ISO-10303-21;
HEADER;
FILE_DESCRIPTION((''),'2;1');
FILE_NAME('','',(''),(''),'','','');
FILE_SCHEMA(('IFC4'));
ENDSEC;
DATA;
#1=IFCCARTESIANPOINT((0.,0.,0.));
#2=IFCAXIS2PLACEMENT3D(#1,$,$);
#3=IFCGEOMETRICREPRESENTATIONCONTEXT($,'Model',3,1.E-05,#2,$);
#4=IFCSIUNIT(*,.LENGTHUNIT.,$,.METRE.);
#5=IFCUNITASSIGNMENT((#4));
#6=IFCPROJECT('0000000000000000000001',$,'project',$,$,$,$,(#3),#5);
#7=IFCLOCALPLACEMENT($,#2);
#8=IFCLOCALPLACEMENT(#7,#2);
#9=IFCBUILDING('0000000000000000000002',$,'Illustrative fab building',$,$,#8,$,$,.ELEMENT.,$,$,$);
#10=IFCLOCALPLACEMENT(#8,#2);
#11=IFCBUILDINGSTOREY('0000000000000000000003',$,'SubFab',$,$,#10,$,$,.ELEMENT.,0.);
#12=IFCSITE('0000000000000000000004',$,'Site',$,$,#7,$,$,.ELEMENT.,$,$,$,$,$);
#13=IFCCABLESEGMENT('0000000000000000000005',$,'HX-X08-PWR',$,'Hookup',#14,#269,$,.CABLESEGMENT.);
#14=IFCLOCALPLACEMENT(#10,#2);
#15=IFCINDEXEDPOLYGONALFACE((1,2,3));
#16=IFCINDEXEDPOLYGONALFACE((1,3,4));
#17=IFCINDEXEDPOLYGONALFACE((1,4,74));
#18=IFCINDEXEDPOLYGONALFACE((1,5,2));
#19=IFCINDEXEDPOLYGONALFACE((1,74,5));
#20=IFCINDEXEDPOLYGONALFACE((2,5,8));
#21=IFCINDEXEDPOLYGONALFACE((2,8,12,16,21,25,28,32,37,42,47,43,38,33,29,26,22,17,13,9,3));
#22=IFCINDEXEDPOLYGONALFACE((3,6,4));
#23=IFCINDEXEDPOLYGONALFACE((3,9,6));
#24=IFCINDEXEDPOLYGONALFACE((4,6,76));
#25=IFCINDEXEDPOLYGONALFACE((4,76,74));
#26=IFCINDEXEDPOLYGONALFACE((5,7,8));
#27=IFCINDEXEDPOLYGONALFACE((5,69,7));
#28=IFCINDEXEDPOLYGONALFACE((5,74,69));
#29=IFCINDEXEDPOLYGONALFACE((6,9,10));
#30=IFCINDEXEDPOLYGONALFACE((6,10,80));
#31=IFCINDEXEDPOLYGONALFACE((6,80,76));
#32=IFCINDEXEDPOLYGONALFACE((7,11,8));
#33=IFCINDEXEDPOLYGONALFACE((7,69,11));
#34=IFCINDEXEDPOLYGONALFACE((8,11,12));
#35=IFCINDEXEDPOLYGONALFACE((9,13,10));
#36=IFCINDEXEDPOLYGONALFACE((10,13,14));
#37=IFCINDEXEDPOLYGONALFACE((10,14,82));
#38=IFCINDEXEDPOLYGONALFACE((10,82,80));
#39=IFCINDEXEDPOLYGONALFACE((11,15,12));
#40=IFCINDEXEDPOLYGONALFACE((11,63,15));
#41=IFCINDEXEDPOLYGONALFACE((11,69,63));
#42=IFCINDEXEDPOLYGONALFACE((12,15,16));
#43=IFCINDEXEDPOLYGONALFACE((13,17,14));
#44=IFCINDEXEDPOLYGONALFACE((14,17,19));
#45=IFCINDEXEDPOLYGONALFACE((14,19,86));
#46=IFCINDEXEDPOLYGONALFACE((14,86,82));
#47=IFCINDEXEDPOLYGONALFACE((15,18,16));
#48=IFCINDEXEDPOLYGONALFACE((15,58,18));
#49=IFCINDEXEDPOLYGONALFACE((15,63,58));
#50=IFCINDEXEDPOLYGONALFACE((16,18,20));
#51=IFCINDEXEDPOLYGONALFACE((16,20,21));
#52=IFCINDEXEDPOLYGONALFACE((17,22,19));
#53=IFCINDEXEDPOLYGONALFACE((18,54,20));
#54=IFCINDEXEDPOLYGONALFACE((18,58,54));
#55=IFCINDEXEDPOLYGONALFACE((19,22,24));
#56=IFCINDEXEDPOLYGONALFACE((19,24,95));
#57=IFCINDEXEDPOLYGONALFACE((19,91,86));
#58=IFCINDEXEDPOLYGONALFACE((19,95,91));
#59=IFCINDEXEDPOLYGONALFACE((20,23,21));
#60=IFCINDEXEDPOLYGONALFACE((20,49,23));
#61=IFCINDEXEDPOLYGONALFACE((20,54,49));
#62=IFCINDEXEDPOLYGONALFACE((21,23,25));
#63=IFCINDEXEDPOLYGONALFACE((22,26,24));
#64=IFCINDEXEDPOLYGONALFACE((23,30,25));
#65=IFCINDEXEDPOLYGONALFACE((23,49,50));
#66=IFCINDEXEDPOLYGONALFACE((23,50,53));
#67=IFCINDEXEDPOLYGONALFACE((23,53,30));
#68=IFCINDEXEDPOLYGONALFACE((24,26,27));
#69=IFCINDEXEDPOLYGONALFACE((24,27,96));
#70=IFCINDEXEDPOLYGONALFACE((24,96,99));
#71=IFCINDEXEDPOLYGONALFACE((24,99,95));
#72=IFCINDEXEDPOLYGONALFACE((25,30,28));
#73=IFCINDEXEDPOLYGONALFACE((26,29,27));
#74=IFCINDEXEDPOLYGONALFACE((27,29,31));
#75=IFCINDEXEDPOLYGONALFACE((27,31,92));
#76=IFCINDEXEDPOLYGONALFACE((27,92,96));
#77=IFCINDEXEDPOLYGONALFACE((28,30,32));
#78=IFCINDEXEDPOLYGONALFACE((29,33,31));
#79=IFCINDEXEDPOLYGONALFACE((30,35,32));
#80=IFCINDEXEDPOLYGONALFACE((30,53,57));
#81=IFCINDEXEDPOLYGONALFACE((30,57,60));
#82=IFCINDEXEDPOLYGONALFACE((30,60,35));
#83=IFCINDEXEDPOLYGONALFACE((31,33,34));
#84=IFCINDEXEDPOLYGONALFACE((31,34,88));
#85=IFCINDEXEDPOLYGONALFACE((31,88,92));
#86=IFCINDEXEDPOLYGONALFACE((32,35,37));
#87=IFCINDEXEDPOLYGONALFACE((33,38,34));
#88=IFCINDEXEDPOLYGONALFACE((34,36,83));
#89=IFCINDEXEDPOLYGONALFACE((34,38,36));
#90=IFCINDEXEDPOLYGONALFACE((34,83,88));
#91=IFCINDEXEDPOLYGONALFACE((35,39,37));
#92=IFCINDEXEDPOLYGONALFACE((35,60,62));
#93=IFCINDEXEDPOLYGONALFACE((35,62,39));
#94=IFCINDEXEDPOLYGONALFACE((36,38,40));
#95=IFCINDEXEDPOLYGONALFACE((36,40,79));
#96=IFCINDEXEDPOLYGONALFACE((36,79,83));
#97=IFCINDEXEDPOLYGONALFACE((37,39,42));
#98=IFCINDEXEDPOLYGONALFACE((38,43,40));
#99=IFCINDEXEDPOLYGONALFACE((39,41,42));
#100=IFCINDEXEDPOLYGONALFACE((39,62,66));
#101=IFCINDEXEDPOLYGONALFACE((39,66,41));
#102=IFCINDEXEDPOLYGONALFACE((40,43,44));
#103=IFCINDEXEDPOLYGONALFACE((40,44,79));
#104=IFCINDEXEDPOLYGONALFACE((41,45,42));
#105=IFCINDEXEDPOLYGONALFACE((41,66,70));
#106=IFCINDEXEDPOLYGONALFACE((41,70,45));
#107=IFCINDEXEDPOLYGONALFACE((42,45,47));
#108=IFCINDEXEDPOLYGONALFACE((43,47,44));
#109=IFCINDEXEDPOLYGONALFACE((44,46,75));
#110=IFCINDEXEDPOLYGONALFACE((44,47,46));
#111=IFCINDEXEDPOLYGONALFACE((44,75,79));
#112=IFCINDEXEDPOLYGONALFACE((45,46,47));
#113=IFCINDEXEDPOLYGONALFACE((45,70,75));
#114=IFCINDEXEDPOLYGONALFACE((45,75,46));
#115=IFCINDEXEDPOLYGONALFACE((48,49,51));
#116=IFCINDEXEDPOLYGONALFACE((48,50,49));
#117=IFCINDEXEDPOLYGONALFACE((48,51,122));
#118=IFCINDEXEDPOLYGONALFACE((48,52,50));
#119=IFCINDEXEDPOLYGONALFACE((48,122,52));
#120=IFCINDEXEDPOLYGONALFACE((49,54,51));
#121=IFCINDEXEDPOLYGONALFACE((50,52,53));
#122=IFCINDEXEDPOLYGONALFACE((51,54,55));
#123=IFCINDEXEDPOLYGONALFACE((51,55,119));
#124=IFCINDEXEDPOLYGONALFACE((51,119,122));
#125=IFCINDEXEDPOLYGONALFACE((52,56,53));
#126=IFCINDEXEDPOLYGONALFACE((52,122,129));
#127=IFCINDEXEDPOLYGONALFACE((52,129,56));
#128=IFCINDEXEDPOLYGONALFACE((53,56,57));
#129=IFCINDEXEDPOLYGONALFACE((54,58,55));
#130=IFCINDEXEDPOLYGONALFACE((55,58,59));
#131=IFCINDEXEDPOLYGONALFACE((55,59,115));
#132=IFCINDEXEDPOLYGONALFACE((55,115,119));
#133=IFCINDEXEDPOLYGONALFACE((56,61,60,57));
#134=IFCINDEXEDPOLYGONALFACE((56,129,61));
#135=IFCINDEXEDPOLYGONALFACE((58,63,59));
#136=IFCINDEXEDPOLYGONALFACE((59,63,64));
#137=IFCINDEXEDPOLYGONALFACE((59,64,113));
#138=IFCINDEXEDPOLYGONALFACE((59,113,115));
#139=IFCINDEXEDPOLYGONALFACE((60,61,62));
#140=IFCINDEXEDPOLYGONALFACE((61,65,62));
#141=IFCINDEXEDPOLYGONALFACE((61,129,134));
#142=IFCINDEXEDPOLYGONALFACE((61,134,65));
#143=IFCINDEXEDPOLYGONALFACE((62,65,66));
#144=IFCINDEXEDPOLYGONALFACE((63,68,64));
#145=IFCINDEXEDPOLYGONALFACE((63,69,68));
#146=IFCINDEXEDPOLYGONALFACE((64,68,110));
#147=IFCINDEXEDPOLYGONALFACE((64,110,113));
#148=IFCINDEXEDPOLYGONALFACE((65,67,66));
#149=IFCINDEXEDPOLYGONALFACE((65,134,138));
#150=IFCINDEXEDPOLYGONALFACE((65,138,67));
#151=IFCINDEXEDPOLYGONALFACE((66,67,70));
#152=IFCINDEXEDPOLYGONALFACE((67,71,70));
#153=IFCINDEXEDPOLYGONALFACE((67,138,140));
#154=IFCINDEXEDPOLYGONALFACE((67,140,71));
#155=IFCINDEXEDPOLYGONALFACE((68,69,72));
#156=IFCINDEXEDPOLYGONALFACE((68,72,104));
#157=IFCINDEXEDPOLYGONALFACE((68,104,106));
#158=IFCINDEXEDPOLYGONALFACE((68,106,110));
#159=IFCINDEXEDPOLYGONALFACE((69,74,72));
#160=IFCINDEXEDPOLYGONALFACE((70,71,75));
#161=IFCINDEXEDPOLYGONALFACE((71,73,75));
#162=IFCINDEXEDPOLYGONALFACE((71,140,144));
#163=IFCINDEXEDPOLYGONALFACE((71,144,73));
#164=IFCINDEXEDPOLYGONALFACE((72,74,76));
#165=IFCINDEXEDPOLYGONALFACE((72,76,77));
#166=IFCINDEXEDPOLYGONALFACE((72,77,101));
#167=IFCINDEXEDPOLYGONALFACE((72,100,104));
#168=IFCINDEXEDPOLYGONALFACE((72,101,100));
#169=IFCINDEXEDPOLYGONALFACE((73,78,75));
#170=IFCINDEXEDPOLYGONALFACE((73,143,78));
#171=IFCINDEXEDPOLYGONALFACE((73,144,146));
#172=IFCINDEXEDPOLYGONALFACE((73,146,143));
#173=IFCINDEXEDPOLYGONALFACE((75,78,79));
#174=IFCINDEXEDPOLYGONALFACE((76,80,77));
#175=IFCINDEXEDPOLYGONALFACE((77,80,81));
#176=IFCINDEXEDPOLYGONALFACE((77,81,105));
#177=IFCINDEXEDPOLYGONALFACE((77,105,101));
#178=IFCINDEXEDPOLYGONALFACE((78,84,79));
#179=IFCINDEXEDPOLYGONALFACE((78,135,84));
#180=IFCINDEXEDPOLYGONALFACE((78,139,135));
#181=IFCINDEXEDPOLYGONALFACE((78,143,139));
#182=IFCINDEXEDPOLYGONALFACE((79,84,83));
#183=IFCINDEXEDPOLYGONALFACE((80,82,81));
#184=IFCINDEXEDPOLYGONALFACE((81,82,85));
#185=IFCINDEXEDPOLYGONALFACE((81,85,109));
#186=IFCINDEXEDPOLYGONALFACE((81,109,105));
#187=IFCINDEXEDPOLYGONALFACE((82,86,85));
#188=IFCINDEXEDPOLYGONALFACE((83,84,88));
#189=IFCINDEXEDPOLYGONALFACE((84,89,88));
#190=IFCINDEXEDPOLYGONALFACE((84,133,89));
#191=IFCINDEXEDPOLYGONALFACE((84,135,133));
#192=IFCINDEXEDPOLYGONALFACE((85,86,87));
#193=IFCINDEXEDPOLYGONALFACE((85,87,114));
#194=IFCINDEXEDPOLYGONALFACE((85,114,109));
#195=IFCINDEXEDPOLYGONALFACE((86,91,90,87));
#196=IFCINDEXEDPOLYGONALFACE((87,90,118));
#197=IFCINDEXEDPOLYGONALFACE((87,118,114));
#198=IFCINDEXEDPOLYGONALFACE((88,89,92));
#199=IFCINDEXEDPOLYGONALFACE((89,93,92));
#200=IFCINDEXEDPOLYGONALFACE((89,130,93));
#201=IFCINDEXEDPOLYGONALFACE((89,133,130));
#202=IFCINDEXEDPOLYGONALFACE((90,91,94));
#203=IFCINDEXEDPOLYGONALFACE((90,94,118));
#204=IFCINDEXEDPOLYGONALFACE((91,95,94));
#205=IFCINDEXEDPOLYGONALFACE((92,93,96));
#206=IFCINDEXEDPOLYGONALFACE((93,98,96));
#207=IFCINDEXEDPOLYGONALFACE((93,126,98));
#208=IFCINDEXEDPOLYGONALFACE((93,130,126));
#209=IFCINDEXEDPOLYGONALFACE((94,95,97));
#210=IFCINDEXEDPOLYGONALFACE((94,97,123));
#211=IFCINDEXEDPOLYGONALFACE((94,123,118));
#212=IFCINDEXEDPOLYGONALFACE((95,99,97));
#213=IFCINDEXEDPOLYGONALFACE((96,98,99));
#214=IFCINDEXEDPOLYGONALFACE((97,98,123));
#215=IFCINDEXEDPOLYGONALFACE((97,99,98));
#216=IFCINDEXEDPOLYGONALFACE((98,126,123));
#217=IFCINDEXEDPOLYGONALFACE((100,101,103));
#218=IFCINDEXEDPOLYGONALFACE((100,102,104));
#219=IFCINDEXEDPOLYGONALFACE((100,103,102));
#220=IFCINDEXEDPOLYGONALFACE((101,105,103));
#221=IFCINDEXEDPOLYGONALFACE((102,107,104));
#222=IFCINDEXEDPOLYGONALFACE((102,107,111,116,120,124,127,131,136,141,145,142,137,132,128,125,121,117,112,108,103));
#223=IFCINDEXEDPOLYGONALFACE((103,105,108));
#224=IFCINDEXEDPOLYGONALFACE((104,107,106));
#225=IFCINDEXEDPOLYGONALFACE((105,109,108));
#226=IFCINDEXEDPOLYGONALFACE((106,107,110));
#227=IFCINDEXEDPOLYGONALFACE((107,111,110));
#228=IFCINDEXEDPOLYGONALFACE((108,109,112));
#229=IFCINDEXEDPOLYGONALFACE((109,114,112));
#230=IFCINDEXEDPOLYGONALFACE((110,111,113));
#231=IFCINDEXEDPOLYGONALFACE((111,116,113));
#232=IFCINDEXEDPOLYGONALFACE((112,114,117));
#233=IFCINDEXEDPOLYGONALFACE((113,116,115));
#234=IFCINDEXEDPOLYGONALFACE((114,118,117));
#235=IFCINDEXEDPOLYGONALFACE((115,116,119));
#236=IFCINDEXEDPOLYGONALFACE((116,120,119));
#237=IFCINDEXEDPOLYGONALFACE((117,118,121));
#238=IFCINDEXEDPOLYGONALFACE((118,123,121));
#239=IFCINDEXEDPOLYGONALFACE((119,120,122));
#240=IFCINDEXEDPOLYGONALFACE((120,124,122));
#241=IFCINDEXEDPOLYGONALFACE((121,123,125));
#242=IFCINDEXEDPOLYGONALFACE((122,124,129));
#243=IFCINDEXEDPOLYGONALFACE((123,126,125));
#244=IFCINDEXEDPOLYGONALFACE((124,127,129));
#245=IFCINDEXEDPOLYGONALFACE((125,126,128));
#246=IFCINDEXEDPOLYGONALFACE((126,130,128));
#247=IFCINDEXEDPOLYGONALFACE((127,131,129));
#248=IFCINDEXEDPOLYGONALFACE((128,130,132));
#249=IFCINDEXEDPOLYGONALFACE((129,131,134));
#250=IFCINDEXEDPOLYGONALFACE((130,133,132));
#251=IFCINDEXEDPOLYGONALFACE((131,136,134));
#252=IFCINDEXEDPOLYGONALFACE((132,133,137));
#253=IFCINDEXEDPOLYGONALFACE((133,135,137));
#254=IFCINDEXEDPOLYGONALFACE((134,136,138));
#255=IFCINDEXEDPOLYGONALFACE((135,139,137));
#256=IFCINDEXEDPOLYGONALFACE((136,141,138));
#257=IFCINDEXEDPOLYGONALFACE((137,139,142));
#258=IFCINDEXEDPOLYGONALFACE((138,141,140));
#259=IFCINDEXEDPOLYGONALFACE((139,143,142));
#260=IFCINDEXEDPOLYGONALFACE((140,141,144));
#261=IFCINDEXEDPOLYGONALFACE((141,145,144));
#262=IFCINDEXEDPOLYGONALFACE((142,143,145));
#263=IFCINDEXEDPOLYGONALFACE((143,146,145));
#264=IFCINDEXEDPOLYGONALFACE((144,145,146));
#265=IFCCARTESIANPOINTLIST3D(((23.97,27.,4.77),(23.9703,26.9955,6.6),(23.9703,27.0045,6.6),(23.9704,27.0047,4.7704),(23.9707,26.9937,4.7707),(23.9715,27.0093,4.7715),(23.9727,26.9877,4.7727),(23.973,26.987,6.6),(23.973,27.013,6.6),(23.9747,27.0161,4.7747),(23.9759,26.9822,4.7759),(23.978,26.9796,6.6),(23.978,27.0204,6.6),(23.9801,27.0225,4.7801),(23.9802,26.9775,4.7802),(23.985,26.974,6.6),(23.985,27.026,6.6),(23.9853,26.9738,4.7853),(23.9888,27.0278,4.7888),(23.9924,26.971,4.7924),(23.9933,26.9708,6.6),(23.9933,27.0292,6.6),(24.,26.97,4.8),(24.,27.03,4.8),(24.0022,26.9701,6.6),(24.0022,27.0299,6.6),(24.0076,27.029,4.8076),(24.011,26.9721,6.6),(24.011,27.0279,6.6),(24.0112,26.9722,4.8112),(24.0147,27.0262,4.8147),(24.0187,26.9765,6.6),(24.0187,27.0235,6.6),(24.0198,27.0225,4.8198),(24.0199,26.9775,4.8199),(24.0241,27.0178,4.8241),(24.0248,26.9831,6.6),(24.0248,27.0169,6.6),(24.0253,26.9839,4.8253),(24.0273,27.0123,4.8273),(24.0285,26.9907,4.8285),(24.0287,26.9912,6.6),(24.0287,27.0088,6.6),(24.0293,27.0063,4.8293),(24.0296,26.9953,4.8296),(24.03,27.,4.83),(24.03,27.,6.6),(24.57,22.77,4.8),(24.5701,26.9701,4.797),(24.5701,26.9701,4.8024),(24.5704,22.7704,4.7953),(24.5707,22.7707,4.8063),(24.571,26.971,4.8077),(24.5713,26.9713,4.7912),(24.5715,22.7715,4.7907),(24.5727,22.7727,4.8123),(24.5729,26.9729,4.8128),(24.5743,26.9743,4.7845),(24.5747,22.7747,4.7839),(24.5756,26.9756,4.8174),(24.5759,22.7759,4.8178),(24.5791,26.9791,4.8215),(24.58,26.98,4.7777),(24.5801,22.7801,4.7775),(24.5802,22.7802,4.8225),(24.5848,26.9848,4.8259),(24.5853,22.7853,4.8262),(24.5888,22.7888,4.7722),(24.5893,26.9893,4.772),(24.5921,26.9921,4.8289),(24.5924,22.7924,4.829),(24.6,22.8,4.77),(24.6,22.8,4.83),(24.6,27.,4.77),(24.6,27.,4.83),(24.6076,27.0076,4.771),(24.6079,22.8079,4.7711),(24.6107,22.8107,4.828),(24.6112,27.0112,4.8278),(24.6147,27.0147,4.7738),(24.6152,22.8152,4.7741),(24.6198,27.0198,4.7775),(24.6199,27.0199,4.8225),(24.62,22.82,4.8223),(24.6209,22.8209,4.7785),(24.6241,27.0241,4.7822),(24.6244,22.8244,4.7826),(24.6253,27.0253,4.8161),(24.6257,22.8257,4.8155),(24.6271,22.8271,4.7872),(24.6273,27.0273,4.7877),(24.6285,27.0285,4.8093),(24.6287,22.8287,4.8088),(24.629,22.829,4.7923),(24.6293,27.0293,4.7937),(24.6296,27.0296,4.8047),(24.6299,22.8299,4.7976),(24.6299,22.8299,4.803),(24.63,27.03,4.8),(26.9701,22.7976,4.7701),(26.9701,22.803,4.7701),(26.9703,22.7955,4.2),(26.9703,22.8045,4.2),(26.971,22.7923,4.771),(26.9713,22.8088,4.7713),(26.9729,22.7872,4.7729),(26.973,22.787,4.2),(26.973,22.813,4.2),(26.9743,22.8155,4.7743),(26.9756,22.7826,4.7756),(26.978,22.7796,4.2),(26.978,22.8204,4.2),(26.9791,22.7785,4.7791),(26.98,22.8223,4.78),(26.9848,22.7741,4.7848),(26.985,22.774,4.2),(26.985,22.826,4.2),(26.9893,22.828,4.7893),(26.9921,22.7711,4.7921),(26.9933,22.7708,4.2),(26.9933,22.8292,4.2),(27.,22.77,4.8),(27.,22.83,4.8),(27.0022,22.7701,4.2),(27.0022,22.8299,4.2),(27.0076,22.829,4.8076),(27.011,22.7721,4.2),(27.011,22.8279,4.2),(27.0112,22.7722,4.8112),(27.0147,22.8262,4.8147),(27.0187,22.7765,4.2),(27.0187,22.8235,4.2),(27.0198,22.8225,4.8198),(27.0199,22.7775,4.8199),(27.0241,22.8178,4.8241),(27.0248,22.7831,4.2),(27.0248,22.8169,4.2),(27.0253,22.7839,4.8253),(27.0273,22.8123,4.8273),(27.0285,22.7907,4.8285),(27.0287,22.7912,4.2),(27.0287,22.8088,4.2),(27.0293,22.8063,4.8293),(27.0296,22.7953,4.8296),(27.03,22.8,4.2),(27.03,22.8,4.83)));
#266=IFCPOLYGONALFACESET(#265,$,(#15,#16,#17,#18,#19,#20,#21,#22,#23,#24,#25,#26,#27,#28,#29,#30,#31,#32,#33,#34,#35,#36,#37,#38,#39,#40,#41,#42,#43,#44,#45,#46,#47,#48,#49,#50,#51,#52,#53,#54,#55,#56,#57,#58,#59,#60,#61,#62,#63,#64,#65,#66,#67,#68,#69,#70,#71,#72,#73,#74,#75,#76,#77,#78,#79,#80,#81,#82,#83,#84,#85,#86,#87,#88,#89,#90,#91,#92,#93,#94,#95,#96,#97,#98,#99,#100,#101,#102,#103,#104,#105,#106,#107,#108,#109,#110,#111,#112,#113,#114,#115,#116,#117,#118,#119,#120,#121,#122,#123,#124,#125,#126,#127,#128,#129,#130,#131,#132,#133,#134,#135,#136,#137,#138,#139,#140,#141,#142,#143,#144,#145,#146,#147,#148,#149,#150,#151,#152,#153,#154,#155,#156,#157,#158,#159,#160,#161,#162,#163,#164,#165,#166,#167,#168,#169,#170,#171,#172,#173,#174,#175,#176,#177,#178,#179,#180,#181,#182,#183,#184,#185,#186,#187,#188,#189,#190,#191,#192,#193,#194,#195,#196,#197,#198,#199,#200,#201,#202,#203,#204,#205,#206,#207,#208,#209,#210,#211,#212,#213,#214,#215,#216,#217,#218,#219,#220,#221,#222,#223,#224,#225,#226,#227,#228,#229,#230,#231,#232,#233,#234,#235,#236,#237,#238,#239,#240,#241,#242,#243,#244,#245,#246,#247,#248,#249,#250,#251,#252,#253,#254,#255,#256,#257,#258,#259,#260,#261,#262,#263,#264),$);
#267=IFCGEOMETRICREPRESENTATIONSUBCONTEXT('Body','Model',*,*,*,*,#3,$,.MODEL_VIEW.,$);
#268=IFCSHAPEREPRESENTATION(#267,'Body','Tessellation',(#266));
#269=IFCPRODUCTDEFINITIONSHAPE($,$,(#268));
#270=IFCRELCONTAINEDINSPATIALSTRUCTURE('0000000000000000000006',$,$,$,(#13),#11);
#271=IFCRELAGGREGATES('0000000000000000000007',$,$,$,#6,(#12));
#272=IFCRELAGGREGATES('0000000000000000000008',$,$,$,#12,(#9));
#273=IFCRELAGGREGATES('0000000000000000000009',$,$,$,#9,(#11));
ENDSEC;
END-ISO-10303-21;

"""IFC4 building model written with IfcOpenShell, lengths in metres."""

from ifc_helpers import new_model, entity, si_unit, origin, place, context, subcontext, project, spatial, element, save


model = new_model("IFC4")

# Units and contexts
model_context = context("Model", 3, precision=1e-05, world=origin())
body_context = subcontext(model_context, "Body", "Model", "MODEL_VIEW")
ifc_project = project(units=[si_unit("LENGTHUNIT", "METRE")], contexts=[model_context])

# Site, building, storey
site_placement = place(None, origin())
site = spatial("IfcSite", under=ifc_project, at=site_placement, Name="Site", CompositionType="ELEMENT")
building_placement = place(site_placement, origin())
building = spatial("IfcBuilding", under=site, at=building_placement, Name="Illustrative fab building", CompositionType="ELEMENT")
storey_placement = place(building_placement, origin())
storey = spatial("IfcBuildingStorey", under=building, at=storey_placement, Name="SubFab", CompositionType="ELEMENT", Elevation=0.0)

# Cable segment
cable_segment_1_placement = place(storey_placement, origin())
element("IfcCableSegment", 1, at=cable_segment_1_placement, inside=storey, Name="HX-X08-PWR", ObjectType="Hookup", PredefinedType="CABLESEGMENT", context=body_context, shape_type="AdvancedSweptSolid", body=[
    entity("IfcSweptDiskSolid", entity("IfcPolyline", [entity("IfcCartesianPoint", [27.0, 22.8, 4.2]), entity("IfcCartesianPoint", [27.0, 22.8, 4.8]), entity("IfcCartesianPoint", [24.6, 22.8, 4.8]), entity("IfcCartesianPoint", [24.6, 27.0, 4.8]), entity("IfcCartesianPoint", [24.0, 27.0, 4.8]), entity("IfcCartesianPoint", [24.0, 27.0, 6.6])]), 0.03),
])

save(model, "model.ifc")
